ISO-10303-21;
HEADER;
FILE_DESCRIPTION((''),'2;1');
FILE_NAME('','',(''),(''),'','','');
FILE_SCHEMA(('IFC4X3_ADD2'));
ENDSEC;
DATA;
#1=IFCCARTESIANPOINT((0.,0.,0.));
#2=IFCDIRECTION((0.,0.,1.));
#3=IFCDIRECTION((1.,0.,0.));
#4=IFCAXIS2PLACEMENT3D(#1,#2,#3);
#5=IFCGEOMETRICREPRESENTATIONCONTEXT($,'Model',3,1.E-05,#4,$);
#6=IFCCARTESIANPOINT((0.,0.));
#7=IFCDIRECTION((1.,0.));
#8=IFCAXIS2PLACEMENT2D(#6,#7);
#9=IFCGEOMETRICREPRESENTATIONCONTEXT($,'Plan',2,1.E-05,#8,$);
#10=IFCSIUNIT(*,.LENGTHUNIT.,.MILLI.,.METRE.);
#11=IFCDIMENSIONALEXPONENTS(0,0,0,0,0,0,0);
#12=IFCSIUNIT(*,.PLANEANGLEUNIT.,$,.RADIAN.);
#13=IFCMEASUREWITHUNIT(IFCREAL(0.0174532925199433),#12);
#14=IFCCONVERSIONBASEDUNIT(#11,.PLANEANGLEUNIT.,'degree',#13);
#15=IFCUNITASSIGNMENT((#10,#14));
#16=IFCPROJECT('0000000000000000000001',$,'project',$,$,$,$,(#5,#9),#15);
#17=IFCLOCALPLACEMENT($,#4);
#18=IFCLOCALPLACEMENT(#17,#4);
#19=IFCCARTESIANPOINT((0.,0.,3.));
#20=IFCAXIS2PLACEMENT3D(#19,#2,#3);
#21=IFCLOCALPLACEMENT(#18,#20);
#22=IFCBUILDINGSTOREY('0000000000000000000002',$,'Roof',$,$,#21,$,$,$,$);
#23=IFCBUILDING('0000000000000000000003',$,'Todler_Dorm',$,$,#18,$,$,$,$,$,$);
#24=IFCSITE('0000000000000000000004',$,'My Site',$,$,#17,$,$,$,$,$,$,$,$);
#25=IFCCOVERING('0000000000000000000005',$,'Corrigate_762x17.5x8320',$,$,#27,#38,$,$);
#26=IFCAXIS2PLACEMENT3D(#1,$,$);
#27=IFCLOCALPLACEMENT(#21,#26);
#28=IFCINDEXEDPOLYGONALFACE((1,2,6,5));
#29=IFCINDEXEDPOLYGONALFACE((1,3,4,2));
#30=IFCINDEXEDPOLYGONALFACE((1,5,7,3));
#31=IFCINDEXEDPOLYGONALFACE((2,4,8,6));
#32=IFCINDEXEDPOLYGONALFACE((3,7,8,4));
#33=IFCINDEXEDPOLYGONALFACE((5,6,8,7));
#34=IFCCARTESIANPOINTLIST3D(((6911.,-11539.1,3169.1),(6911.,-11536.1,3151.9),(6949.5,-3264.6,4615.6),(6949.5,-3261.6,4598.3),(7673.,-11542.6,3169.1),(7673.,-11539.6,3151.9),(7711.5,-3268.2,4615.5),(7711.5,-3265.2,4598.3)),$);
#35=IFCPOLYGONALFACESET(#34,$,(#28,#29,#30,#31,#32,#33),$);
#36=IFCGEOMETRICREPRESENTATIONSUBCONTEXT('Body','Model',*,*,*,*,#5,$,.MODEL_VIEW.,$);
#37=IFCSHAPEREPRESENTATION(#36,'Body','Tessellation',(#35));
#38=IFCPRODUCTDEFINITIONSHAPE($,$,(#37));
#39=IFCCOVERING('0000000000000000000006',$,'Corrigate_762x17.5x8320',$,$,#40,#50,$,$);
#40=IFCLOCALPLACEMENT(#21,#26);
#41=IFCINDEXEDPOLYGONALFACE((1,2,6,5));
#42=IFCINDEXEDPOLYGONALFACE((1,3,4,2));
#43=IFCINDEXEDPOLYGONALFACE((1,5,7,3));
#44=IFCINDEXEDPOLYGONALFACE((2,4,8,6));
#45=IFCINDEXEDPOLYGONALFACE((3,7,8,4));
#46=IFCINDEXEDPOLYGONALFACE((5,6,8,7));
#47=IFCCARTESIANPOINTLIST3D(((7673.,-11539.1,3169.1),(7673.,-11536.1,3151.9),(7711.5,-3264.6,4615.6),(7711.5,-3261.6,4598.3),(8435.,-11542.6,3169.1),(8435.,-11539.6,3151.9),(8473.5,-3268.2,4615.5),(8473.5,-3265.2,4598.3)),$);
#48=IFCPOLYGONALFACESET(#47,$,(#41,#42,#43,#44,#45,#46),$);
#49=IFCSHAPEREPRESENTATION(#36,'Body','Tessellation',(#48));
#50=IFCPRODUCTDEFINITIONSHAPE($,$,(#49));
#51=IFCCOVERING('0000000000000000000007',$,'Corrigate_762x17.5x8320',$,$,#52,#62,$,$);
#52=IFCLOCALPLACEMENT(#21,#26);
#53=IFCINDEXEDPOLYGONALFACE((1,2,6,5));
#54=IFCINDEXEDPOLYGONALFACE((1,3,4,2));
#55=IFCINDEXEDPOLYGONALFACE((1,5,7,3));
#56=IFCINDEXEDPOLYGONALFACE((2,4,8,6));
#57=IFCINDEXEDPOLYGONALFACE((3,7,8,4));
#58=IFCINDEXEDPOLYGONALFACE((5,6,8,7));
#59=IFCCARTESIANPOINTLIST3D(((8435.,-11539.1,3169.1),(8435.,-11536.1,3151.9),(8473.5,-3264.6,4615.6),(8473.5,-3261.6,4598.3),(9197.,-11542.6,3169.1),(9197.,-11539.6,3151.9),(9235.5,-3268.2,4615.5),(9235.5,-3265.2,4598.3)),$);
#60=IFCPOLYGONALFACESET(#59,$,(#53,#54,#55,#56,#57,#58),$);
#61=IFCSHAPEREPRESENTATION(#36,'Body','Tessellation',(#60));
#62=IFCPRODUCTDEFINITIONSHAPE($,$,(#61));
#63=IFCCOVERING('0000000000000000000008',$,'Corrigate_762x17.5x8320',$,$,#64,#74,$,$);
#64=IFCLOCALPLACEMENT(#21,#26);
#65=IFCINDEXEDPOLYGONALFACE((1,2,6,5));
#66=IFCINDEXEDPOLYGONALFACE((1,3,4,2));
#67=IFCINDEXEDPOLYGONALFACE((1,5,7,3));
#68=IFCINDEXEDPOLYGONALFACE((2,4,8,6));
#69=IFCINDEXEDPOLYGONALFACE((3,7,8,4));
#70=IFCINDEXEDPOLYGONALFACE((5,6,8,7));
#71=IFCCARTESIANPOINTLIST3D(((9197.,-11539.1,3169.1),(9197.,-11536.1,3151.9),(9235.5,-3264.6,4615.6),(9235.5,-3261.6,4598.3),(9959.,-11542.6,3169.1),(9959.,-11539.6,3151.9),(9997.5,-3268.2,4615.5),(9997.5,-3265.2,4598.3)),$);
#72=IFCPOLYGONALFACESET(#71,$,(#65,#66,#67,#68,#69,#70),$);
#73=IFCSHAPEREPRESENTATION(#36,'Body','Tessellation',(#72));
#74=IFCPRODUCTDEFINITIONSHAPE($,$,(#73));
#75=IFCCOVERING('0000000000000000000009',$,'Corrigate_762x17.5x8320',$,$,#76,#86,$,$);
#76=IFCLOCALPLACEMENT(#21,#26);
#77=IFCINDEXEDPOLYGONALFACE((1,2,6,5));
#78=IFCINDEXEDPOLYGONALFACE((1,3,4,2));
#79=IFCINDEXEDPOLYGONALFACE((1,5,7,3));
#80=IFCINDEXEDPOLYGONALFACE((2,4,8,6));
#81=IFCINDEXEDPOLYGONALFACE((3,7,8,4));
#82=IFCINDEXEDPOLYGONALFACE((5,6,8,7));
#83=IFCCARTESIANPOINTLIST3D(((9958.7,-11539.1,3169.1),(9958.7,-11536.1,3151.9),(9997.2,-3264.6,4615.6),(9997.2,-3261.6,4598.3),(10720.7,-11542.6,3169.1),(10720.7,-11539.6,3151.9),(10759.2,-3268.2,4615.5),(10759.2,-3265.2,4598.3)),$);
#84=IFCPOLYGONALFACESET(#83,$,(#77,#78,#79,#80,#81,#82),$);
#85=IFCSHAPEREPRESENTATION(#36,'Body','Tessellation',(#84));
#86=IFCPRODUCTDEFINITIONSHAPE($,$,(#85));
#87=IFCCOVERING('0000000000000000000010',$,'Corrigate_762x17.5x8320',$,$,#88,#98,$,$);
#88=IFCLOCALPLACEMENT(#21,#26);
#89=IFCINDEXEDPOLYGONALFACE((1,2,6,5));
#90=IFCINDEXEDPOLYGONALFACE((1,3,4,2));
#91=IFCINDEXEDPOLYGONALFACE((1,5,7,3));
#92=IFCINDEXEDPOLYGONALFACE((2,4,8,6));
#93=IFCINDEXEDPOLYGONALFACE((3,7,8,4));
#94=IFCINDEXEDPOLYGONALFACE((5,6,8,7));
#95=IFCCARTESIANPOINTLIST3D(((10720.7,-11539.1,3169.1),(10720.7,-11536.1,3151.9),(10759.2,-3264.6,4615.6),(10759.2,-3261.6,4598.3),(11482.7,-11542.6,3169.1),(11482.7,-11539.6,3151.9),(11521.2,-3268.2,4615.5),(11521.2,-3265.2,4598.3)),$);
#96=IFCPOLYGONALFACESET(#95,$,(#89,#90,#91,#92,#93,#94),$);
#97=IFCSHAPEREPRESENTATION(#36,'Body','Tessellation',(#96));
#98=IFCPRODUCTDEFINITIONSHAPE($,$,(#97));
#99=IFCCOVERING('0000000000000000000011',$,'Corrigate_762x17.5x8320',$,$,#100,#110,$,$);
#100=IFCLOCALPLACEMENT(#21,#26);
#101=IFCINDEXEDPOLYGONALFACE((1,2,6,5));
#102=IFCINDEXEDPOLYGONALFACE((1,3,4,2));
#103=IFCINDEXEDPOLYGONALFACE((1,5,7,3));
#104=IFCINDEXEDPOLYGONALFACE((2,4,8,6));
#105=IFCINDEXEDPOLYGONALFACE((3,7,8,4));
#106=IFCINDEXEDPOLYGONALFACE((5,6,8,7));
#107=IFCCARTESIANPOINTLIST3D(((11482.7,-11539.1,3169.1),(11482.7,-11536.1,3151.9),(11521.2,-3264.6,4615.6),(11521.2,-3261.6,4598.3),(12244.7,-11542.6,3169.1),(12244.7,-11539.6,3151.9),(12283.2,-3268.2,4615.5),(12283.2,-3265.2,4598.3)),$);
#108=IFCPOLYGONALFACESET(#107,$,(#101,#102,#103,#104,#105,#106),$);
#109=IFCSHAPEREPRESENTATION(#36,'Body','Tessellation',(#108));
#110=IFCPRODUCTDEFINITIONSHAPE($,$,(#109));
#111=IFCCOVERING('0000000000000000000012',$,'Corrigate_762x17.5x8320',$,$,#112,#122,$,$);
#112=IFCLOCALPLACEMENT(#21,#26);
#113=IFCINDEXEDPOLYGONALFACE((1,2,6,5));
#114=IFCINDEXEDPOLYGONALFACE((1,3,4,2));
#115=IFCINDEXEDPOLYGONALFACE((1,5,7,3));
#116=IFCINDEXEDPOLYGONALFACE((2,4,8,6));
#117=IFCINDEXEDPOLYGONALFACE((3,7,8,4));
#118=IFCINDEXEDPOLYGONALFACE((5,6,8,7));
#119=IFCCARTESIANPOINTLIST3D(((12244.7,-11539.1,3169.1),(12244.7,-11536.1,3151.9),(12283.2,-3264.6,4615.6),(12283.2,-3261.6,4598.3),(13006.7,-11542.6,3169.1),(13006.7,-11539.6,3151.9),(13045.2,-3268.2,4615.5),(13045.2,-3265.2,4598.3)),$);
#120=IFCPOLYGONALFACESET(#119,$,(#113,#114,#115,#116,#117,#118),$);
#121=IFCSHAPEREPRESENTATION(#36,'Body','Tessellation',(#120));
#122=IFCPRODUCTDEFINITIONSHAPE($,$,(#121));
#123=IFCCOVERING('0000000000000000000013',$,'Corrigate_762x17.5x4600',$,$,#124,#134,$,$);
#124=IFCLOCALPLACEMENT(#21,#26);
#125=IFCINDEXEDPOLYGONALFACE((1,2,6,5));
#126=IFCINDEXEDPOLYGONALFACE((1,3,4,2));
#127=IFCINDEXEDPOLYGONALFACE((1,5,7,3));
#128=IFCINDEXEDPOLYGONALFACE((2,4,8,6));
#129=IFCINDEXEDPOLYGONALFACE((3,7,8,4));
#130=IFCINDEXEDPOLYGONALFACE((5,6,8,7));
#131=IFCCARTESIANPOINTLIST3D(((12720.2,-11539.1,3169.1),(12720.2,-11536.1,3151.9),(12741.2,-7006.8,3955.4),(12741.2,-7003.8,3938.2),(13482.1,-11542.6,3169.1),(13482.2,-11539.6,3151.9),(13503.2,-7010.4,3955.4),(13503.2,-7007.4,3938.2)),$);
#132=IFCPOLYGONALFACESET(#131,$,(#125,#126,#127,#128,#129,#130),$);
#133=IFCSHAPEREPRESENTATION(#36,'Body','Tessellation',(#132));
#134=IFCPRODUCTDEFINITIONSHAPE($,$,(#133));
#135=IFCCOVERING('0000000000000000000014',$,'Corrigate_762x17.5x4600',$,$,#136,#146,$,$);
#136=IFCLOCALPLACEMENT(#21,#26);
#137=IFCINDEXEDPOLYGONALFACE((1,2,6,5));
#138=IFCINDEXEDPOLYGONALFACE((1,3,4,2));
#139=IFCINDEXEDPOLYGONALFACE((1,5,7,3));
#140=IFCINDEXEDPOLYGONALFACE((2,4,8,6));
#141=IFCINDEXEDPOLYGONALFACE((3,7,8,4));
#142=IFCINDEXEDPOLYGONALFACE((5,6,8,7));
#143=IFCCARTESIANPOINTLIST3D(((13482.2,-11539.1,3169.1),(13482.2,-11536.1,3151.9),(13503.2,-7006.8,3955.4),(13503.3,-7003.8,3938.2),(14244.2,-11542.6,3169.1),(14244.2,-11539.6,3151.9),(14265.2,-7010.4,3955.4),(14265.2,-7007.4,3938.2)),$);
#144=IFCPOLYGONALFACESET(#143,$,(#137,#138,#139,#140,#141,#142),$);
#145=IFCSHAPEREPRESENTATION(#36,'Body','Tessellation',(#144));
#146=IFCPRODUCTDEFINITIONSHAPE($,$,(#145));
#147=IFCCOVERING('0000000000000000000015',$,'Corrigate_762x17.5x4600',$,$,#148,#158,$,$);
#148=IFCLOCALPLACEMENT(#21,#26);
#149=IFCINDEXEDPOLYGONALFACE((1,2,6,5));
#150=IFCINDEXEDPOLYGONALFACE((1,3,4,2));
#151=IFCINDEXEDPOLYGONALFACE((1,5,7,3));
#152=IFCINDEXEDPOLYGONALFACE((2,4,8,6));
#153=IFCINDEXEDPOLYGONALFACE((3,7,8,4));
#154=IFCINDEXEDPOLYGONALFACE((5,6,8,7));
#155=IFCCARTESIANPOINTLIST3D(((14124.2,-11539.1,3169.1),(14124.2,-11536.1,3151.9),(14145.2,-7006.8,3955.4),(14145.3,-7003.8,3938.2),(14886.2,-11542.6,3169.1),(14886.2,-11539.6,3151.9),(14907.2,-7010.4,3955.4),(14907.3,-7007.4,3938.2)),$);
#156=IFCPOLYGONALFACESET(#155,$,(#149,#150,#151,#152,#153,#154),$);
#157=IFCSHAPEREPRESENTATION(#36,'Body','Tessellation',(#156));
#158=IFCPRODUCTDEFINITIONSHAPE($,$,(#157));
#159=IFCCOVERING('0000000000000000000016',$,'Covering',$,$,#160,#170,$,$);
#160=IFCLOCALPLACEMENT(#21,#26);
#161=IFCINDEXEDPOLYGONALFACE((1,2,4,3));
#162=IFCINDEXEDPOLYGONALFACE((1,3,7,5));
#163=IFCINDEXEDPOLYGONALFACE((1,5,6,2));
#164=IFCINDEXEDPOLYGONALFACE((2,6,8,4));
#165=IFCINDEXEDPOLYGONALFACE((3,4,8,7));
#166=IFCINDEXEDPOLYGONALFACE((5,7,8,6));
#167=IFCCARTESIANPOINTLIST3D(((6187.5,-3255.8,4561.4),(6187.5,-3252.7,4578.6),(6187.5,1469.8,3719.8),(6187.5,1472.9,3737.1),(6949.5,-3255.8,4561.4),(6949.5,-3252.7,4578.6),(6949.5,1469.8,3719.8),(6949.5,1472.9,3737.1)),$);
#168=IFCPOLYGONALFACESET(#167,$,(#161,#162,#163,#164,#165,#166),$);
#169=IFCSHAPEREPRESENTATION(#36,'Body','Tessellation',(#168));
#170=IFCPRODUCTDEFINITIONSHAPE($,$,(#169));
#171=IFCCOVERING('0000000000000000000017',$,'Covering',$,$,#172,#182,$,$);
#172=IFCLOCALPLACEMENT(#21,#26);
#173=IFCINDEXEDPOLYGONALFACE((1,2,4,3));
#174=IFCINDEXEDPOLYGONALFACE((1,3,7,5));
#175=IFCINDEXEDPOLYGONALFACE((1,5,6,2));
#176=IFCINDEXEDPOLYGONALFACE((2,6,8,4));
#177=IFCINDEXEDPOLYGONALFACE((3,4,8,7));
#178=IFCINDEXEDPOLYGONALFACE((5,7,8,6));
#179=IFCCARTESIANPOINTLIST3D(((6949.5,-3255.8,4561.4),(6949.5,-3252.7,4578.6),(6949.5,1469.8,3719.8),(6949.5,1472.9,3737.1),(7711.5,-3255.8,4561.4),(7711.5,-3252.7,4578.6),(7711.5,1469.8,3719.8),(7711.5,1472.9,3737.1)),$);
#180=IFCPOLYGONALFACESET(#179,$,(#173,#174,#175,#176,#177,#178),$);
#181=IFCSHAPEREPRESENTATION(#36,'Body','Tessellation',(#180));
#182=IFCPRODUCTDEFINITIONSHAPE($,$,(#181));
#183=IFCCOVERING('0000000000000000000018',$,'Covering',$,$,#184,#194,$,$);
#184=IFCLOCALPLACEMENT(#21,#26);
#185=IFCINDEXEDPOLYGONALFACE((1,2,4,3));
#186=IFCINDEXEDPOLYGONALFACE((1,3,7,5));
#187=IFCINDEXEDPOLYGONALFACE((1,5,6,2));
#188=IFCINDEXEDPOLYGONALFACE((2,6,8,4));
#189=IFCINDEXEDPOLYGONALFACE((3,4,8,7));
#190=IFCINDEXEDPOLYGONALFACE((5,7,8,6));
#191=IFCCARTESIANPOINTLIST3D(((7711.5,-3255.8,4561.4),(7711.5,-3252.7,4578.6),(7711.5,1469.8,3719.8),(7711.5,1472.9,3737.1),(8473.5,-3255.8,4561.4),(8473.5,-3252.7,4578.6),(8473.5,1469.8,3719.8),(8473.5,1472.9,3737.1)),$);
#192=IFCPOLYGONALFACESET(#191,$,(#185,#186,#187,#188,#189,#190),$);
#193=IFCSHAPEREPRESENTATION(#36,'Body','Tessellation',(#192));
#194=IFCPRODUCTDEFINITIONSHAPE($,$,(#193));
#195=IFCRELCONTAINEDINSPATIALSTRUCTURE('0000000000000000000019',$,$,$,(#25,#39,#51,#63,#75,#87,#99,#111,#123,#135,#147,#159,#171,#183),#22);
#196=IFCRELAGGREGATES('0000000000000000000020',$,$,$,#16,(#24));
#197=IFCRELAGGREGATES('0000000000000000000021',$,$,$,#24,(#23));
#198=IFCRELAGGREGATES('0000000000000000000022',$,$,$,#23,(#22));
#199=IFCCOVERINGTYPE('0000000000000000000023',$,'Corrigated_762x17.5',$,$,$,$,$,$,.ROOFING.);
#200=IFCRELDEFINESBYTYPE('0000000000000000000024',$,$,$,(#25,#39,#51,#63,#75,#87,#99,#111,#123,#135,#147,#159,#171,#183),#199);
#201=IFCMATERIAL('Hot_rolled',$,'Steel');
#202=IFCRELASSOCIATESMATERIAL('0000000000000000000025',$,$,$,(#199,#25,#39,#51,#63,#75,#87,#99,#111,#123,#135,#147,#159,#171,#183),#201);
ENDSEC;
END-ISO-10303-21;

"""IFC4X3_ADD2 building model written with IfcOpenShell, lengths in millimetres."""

from ifc_helpers import new_model, entity, si_unit, converted_unit, frame, origin_with_axes, origin_2d_with_axis, place, context, subcontext, project, spatial, rectangle, extrude, material, material_profile, profile_set, profile_usage, type_object, element, save


model = new_model("IFC4X3_ADD2")

# Units and contexts
model_context = context("Model", 3, precision=1e-05, world=origin_with_axes())
plan_context = context("Plan", 2, precision=1e-05, world=origin_2d_with_axis())
body_context = subcontext(model_context, "Body", "Model", "MODEL_VIEW")
ifc_project = project(units=[si_unit("LENGTHUNIT", "METRE", prefix="MILLI"), converted_unit("PLANEANGLEUNIT", "degree", entity("IfcReal", 0.0174532925199433), si_unit("PLANEANGLEUNIT", "RADIAN"), dimensions=[0, 0, 0, 0, 0, 0, 0])], contexts=[model_context, plan_context])

# Site, building, storey
site_placement = place(None, origin_with_axes())
site = spatial("IfcSite", under=ifc_project, at=site_placement, Name="My Site")
building_placement = place(site_placement, origin_with_axes())
building = spatial("IfcBuilding", under=site, at=building_placement, Name="Todler_Dorm")
storey_placement = place(building_placement, frame((0.0, 0.0, 3.0), z_axis=(0.0, 0.0, 1.0), x_axis=(1.0, 0.0, 0.0)))
storey = spatial("IfcBuildingStorey", under=building, at=storey_placement, Name="Roof")

# Coverings
ifc_material_1 = material(Name="Hot_rolled", Category="Steel")
ifc_material_profile = material_profile(ifc_material_1, rectangle(XDim=762.0, YDim=17.5))
ifc_profile_set = profile_set([ifc_material_profile])
ifc_profile_usage_1 = profile_usage(ifc_profile_set, cardinal=5)
covering_type = type_object("IfcCoveringType", Name="Corrigated_762x17.5", PredefinedType="ROOFING", material=ifc_profile_set)
covering_1_placement = place(storey_placement, frame((7330.5, -3264.9, 4606.9), z_axis=(-0.004582, -0.985052, -0.172196), x_axis=(0.999989, -0.00465, -0.000006)))
element("IfcCovering", 1, at=covering_1_placement, inside=storey, type_object=covering_type, material=ifc_profile_usage_1, Name="Corrigate_762x17.5x8320", context=body_context, shape_type="SweptSolid", body=[
    extrude(rectangle(XDim=762.0, YDim=17.5), origin_with_axes(), (0.0, 0.0, 1.0), 8400.0),
])
ifc_profile_usage_2 = profile_usage(ifc_profile_set, cardinal=5)
covering_2_placement = place(storey_placement, frame((8092.5, -3264.9, 4606.9), z_axis=(-0.004582, -0.985052, -0.172196), x_axis=(0.999989, -0.00465, -0.000006)))
element("IfcCovering", 2, at=covering_2_placement, inside=storey, type_object=covering_type, material=ifc_profile_usage_2, Name="Corrigate_762x17.5x8320", context=body_context, shape_type="SweptSolid", body=[
    extrude(rectangle(XDim=762.0, YDim=17.5), origin_with_axes(), (0.0, 0.0, 1.0), 8400.0),
])
ifc_profile_usage_3 = profile_usage(ifc_profile_set, cardinal=5)
covering_3_placement = place(storey_placement, frame((8854.5, -3264.9, 4606.9), z_axis=(-0.004582, -0.985052, -0.172196), x_axis=(0.999989, -0.00465, -0.000006)))
element("IfcCovering", 3, at=covering_3_placement, inside=storey, type_object=covering_type, material=ifc_profile_usage_3, Name="Corrigate_762x17.5x8320", context=body_context, shape_type="SweptSolid", body=[
    extrude(rectangle(XDim=762.0, YDim=17.5), origin_with_axes(), (0.0, 0.0, 1.0), 8400.0),
])
ifc_profile_usage_4 = profile_usage(ifc_profile_set, cardinal=5)
covering_4_placement = place(storey_placement, frame((9616.5, -3264.9, 4606.9), z_axis=(-0.004582, -0.985052, -0.172196), x_axis=(0.999989, -0.00465, -0.000006)))
element("IfcCovering", 4, at=covering_4_placement, inside=storey, type_object=covering_type, material=ifc_profile_usage_4, Name="Corrigate_762x17.5x8320", context=body_context, shape_type="SweptSolid", body=[
    extrude(rectangle(XDim=762.0, YDim=17.5), origin_with_axes(), (0.0, 0.0, 1.0), 8400.0),
])
ifc_profile_usage_5 = profile_usage(ifc_profile_set, cardinal=5)
covering_5_placement = place(storey_placement, frame((10378.2, -3264.9, 4606.9), z_axis=(-0.004582, -0.985052, -0.172196), x_axis=(0.999989, -0.00465, -0.000006)))
element("IfcCovering", 5, at=covering_5_placement, inside=storey, type_object=covering_type, material=ifc_profile_usage_5, Name="Corrigate_762x17.5x8320", context=body_context, shape_type="SweptSolid", body=[
    extrude(rectangle(XDim=762.0, YDim=17.5), origin_with_axes(), (0.0, 0.0, 1.0), 8400.0),
])
ifc_profile_usage_6 = profile_usage(ifc_profile_set, cardinal=5)
covering_6_placement = place(storey_placement, frame((11140.2, -3264.9, 4606.9), z_axis=(-0.004582, -0.985052, -0.172196), x_axis=(0.999989, -0.00465, -0.000006)))
element("IfcCovering", 6, at=covering_6_placement, inside=storey, type_object=covering_type, material=ifc_profile_usage_6, Name="Corrigate_762x17.5x8320", context=body_context, shape_type="SweptSolid", body=[
    extrude(rectangle(XDim=762.0, YDim=17.5), origin_with_axes(), (0.0, 0.0, 1.0), 8400.0),
])
ifc_profile_usage_7 = profile_usage(ifc_profile_set, cardinal=5)
covering_7_placement = place(storey_placement, frame((11902.2, -3264.9, 4606.9), z_axis=(-0.004582, -0.985052, -0.172196), x_axis=(0.999989, -0.00465, -0.000006)))
element("IfcCovering", 7, at=covering_7_placement, inside=storey, type_object=covering_type, material=ifc_profile_usage_7, Name="Corrigate_762x17.5x8320", context=body_context, shape_type="SweptSolid", body=[
    extrude(rectangle(XDim=762.0, YDim=17.5), origin_with_axes(), (0.0, 0.0, 1.0), 8400.0),
])
ifc_profile_usage_8 = profile_usage(ifc_profile_set, cardinal=5)
covering_8_placement = place(storey_placement, frame((12664.2, -3264.9, 4606.9), z_axis=(-0.004582, -0.985052, -0.172196), x_axis=(0.999989, -0.00465, -0.000006)))
element("IfcCovering", 8, at=covering_8_placement, inside=storey, type_object=covering_type, material=ifc_profile_usage_8, Name="Corrigate_762x17.5x8320", context=body_context, shape_type="SweptSolid", body=[
    extrude(rectangle(XDim=762.0, YDim=17.5), origin_with_axes(), (0.0, 0.0, 1.0), 8400.0),
])
ifc_profile_usage_9 = profile_usage(ifc_profile_set, cardinal=5)
covering_9_placement = place(storey_placement, frame((13101.2, -11539.3, 3160.5), z_axis=(0.004582, 0.98527, 0.170942), x_axis=(-0.999989, 0.00465, 0.0)))
element("IfcCovering", 9, at=covering_9_placement, inside=storey, type_object=covering_type, material=ifc_profile_usage_9, Name="Corrigate_762x17.5x4600", context=body_context, shape_type="SweptSolid", body=[
    extrude(rectangle(XDim=762.0, YDim=17.5), origin_with_axes(), (0.0, 0.0, 1.0), 4600.0),
])
ifc_profile_usage_10 = profile_usage(ifc_profile_set, cardinal=5)
covering_10_placement = place(storey_placement, frame((13863.2, -11539.3, 3160.5), z_axis=(0.004582, 0.98527, 0.170942), x_axis=(-0.999989, 0.00465, 0.0)))
element("IfcCovering", 10, at=covering_10_placement, inside=storey, type_object=covering_type, material=ifc_profile_usage_10, Name="Corrigate_762x17.5x4600", context=body_context, shape_type="SweptSolid", body=[
    extrude(rectangle(XDim=762.0, YDim=17.5), origin_with_axes(), (0.0, 0.0, 1.0), 4600.0),
])
ifc_profile_usage_11 = profile_usage(ifc_profile_set, cardinal=5)
covering_11_placement = place(storey_placement, frame((14505.2, -11539.3, 3160.5), z_axis=(0.004582, 0.98527, 0.170942), x_axis=(-0.999989, 0.00465, 0.0)))
element("IfcCovering", 11, at=covering_11_placement, inside=storey, type_object=covering_type, material=ifc_profile_usage_11, Name="Corrigate_762x17.5x4600", context=body_context, shape_type="SweptSolid", body=[
    extrude(rectangle(XDim=762.0, YDim=17.5), origin_with_axes(), (0.0, 0.0, 1.0), 4600.0),
])
ifc_profile_usage_12 = profile_usage(ifc_profile_set, cardinal=5)
covering_12_placement = place(storey_placement, frame((6568.5, 1471.4, 3728.4), z_axis=(0.0, -0.98451, 0.175329), x_axis=(1.0, 0.0, 0.0)))
element("IfcCovering", 12, at=covering_12_placement, inside=storey, type_object=covering_type, material=ifc_profile_usage_12, Name="Covering", context=body_context, shape_type="SweptSolid", body=[
    extrude(rectangle(XDim=762.0, YDim=17.5), origin_with_axes(), (0.0, 0.0, 1.0), 4800.0),
])
ifc_profile_usage_13 = profile_usage(ifc_profile_set, cardinal=5)
covering_13_placement = place(storey_placement, frame((7330.5, 1471.4, 3728.4), z_axis=(0.0, -0.98451, 0.175329), x_axis=(1.0, 0.0, 0.0)))
element("IfcCovering", 13, at=covering_13_placement, inside=storey, type_object=covering_type, material=ifc_profile_usage_13, Name="Covering", context=body_context, shape_type="SweptSolid", body=[
    extrude(rectangle(XDim=762.0, YDim=17.5), origin_with_axes(), (0.0, 0.0, 1.0), 4800.0),
])
ifc_profile_usage_14 = profile_usage(ifc_profile_set, cardinal=5)
covering_14_placement = place(storey_placement, frame((8092.5, 1471.4, 3728.4), z_axis=(0.0, -0.98451, 0.175329), x_axis=(1.0, 0.0, 0.0)))
element("IfcCovering", 14, at=covering_14_placement, inside=storey, type_object=covering_type, material=ifc_profile_usage_14, Name="Covering", context=body_context, shape_type="SweptSolid", body=[
    extrude(rectangle(XDim=762.0, YDim=17.5), origin_with_axes(), (0.0, 0.0, 1.0), 4800.0),
])

save(model, "model.ifc")
